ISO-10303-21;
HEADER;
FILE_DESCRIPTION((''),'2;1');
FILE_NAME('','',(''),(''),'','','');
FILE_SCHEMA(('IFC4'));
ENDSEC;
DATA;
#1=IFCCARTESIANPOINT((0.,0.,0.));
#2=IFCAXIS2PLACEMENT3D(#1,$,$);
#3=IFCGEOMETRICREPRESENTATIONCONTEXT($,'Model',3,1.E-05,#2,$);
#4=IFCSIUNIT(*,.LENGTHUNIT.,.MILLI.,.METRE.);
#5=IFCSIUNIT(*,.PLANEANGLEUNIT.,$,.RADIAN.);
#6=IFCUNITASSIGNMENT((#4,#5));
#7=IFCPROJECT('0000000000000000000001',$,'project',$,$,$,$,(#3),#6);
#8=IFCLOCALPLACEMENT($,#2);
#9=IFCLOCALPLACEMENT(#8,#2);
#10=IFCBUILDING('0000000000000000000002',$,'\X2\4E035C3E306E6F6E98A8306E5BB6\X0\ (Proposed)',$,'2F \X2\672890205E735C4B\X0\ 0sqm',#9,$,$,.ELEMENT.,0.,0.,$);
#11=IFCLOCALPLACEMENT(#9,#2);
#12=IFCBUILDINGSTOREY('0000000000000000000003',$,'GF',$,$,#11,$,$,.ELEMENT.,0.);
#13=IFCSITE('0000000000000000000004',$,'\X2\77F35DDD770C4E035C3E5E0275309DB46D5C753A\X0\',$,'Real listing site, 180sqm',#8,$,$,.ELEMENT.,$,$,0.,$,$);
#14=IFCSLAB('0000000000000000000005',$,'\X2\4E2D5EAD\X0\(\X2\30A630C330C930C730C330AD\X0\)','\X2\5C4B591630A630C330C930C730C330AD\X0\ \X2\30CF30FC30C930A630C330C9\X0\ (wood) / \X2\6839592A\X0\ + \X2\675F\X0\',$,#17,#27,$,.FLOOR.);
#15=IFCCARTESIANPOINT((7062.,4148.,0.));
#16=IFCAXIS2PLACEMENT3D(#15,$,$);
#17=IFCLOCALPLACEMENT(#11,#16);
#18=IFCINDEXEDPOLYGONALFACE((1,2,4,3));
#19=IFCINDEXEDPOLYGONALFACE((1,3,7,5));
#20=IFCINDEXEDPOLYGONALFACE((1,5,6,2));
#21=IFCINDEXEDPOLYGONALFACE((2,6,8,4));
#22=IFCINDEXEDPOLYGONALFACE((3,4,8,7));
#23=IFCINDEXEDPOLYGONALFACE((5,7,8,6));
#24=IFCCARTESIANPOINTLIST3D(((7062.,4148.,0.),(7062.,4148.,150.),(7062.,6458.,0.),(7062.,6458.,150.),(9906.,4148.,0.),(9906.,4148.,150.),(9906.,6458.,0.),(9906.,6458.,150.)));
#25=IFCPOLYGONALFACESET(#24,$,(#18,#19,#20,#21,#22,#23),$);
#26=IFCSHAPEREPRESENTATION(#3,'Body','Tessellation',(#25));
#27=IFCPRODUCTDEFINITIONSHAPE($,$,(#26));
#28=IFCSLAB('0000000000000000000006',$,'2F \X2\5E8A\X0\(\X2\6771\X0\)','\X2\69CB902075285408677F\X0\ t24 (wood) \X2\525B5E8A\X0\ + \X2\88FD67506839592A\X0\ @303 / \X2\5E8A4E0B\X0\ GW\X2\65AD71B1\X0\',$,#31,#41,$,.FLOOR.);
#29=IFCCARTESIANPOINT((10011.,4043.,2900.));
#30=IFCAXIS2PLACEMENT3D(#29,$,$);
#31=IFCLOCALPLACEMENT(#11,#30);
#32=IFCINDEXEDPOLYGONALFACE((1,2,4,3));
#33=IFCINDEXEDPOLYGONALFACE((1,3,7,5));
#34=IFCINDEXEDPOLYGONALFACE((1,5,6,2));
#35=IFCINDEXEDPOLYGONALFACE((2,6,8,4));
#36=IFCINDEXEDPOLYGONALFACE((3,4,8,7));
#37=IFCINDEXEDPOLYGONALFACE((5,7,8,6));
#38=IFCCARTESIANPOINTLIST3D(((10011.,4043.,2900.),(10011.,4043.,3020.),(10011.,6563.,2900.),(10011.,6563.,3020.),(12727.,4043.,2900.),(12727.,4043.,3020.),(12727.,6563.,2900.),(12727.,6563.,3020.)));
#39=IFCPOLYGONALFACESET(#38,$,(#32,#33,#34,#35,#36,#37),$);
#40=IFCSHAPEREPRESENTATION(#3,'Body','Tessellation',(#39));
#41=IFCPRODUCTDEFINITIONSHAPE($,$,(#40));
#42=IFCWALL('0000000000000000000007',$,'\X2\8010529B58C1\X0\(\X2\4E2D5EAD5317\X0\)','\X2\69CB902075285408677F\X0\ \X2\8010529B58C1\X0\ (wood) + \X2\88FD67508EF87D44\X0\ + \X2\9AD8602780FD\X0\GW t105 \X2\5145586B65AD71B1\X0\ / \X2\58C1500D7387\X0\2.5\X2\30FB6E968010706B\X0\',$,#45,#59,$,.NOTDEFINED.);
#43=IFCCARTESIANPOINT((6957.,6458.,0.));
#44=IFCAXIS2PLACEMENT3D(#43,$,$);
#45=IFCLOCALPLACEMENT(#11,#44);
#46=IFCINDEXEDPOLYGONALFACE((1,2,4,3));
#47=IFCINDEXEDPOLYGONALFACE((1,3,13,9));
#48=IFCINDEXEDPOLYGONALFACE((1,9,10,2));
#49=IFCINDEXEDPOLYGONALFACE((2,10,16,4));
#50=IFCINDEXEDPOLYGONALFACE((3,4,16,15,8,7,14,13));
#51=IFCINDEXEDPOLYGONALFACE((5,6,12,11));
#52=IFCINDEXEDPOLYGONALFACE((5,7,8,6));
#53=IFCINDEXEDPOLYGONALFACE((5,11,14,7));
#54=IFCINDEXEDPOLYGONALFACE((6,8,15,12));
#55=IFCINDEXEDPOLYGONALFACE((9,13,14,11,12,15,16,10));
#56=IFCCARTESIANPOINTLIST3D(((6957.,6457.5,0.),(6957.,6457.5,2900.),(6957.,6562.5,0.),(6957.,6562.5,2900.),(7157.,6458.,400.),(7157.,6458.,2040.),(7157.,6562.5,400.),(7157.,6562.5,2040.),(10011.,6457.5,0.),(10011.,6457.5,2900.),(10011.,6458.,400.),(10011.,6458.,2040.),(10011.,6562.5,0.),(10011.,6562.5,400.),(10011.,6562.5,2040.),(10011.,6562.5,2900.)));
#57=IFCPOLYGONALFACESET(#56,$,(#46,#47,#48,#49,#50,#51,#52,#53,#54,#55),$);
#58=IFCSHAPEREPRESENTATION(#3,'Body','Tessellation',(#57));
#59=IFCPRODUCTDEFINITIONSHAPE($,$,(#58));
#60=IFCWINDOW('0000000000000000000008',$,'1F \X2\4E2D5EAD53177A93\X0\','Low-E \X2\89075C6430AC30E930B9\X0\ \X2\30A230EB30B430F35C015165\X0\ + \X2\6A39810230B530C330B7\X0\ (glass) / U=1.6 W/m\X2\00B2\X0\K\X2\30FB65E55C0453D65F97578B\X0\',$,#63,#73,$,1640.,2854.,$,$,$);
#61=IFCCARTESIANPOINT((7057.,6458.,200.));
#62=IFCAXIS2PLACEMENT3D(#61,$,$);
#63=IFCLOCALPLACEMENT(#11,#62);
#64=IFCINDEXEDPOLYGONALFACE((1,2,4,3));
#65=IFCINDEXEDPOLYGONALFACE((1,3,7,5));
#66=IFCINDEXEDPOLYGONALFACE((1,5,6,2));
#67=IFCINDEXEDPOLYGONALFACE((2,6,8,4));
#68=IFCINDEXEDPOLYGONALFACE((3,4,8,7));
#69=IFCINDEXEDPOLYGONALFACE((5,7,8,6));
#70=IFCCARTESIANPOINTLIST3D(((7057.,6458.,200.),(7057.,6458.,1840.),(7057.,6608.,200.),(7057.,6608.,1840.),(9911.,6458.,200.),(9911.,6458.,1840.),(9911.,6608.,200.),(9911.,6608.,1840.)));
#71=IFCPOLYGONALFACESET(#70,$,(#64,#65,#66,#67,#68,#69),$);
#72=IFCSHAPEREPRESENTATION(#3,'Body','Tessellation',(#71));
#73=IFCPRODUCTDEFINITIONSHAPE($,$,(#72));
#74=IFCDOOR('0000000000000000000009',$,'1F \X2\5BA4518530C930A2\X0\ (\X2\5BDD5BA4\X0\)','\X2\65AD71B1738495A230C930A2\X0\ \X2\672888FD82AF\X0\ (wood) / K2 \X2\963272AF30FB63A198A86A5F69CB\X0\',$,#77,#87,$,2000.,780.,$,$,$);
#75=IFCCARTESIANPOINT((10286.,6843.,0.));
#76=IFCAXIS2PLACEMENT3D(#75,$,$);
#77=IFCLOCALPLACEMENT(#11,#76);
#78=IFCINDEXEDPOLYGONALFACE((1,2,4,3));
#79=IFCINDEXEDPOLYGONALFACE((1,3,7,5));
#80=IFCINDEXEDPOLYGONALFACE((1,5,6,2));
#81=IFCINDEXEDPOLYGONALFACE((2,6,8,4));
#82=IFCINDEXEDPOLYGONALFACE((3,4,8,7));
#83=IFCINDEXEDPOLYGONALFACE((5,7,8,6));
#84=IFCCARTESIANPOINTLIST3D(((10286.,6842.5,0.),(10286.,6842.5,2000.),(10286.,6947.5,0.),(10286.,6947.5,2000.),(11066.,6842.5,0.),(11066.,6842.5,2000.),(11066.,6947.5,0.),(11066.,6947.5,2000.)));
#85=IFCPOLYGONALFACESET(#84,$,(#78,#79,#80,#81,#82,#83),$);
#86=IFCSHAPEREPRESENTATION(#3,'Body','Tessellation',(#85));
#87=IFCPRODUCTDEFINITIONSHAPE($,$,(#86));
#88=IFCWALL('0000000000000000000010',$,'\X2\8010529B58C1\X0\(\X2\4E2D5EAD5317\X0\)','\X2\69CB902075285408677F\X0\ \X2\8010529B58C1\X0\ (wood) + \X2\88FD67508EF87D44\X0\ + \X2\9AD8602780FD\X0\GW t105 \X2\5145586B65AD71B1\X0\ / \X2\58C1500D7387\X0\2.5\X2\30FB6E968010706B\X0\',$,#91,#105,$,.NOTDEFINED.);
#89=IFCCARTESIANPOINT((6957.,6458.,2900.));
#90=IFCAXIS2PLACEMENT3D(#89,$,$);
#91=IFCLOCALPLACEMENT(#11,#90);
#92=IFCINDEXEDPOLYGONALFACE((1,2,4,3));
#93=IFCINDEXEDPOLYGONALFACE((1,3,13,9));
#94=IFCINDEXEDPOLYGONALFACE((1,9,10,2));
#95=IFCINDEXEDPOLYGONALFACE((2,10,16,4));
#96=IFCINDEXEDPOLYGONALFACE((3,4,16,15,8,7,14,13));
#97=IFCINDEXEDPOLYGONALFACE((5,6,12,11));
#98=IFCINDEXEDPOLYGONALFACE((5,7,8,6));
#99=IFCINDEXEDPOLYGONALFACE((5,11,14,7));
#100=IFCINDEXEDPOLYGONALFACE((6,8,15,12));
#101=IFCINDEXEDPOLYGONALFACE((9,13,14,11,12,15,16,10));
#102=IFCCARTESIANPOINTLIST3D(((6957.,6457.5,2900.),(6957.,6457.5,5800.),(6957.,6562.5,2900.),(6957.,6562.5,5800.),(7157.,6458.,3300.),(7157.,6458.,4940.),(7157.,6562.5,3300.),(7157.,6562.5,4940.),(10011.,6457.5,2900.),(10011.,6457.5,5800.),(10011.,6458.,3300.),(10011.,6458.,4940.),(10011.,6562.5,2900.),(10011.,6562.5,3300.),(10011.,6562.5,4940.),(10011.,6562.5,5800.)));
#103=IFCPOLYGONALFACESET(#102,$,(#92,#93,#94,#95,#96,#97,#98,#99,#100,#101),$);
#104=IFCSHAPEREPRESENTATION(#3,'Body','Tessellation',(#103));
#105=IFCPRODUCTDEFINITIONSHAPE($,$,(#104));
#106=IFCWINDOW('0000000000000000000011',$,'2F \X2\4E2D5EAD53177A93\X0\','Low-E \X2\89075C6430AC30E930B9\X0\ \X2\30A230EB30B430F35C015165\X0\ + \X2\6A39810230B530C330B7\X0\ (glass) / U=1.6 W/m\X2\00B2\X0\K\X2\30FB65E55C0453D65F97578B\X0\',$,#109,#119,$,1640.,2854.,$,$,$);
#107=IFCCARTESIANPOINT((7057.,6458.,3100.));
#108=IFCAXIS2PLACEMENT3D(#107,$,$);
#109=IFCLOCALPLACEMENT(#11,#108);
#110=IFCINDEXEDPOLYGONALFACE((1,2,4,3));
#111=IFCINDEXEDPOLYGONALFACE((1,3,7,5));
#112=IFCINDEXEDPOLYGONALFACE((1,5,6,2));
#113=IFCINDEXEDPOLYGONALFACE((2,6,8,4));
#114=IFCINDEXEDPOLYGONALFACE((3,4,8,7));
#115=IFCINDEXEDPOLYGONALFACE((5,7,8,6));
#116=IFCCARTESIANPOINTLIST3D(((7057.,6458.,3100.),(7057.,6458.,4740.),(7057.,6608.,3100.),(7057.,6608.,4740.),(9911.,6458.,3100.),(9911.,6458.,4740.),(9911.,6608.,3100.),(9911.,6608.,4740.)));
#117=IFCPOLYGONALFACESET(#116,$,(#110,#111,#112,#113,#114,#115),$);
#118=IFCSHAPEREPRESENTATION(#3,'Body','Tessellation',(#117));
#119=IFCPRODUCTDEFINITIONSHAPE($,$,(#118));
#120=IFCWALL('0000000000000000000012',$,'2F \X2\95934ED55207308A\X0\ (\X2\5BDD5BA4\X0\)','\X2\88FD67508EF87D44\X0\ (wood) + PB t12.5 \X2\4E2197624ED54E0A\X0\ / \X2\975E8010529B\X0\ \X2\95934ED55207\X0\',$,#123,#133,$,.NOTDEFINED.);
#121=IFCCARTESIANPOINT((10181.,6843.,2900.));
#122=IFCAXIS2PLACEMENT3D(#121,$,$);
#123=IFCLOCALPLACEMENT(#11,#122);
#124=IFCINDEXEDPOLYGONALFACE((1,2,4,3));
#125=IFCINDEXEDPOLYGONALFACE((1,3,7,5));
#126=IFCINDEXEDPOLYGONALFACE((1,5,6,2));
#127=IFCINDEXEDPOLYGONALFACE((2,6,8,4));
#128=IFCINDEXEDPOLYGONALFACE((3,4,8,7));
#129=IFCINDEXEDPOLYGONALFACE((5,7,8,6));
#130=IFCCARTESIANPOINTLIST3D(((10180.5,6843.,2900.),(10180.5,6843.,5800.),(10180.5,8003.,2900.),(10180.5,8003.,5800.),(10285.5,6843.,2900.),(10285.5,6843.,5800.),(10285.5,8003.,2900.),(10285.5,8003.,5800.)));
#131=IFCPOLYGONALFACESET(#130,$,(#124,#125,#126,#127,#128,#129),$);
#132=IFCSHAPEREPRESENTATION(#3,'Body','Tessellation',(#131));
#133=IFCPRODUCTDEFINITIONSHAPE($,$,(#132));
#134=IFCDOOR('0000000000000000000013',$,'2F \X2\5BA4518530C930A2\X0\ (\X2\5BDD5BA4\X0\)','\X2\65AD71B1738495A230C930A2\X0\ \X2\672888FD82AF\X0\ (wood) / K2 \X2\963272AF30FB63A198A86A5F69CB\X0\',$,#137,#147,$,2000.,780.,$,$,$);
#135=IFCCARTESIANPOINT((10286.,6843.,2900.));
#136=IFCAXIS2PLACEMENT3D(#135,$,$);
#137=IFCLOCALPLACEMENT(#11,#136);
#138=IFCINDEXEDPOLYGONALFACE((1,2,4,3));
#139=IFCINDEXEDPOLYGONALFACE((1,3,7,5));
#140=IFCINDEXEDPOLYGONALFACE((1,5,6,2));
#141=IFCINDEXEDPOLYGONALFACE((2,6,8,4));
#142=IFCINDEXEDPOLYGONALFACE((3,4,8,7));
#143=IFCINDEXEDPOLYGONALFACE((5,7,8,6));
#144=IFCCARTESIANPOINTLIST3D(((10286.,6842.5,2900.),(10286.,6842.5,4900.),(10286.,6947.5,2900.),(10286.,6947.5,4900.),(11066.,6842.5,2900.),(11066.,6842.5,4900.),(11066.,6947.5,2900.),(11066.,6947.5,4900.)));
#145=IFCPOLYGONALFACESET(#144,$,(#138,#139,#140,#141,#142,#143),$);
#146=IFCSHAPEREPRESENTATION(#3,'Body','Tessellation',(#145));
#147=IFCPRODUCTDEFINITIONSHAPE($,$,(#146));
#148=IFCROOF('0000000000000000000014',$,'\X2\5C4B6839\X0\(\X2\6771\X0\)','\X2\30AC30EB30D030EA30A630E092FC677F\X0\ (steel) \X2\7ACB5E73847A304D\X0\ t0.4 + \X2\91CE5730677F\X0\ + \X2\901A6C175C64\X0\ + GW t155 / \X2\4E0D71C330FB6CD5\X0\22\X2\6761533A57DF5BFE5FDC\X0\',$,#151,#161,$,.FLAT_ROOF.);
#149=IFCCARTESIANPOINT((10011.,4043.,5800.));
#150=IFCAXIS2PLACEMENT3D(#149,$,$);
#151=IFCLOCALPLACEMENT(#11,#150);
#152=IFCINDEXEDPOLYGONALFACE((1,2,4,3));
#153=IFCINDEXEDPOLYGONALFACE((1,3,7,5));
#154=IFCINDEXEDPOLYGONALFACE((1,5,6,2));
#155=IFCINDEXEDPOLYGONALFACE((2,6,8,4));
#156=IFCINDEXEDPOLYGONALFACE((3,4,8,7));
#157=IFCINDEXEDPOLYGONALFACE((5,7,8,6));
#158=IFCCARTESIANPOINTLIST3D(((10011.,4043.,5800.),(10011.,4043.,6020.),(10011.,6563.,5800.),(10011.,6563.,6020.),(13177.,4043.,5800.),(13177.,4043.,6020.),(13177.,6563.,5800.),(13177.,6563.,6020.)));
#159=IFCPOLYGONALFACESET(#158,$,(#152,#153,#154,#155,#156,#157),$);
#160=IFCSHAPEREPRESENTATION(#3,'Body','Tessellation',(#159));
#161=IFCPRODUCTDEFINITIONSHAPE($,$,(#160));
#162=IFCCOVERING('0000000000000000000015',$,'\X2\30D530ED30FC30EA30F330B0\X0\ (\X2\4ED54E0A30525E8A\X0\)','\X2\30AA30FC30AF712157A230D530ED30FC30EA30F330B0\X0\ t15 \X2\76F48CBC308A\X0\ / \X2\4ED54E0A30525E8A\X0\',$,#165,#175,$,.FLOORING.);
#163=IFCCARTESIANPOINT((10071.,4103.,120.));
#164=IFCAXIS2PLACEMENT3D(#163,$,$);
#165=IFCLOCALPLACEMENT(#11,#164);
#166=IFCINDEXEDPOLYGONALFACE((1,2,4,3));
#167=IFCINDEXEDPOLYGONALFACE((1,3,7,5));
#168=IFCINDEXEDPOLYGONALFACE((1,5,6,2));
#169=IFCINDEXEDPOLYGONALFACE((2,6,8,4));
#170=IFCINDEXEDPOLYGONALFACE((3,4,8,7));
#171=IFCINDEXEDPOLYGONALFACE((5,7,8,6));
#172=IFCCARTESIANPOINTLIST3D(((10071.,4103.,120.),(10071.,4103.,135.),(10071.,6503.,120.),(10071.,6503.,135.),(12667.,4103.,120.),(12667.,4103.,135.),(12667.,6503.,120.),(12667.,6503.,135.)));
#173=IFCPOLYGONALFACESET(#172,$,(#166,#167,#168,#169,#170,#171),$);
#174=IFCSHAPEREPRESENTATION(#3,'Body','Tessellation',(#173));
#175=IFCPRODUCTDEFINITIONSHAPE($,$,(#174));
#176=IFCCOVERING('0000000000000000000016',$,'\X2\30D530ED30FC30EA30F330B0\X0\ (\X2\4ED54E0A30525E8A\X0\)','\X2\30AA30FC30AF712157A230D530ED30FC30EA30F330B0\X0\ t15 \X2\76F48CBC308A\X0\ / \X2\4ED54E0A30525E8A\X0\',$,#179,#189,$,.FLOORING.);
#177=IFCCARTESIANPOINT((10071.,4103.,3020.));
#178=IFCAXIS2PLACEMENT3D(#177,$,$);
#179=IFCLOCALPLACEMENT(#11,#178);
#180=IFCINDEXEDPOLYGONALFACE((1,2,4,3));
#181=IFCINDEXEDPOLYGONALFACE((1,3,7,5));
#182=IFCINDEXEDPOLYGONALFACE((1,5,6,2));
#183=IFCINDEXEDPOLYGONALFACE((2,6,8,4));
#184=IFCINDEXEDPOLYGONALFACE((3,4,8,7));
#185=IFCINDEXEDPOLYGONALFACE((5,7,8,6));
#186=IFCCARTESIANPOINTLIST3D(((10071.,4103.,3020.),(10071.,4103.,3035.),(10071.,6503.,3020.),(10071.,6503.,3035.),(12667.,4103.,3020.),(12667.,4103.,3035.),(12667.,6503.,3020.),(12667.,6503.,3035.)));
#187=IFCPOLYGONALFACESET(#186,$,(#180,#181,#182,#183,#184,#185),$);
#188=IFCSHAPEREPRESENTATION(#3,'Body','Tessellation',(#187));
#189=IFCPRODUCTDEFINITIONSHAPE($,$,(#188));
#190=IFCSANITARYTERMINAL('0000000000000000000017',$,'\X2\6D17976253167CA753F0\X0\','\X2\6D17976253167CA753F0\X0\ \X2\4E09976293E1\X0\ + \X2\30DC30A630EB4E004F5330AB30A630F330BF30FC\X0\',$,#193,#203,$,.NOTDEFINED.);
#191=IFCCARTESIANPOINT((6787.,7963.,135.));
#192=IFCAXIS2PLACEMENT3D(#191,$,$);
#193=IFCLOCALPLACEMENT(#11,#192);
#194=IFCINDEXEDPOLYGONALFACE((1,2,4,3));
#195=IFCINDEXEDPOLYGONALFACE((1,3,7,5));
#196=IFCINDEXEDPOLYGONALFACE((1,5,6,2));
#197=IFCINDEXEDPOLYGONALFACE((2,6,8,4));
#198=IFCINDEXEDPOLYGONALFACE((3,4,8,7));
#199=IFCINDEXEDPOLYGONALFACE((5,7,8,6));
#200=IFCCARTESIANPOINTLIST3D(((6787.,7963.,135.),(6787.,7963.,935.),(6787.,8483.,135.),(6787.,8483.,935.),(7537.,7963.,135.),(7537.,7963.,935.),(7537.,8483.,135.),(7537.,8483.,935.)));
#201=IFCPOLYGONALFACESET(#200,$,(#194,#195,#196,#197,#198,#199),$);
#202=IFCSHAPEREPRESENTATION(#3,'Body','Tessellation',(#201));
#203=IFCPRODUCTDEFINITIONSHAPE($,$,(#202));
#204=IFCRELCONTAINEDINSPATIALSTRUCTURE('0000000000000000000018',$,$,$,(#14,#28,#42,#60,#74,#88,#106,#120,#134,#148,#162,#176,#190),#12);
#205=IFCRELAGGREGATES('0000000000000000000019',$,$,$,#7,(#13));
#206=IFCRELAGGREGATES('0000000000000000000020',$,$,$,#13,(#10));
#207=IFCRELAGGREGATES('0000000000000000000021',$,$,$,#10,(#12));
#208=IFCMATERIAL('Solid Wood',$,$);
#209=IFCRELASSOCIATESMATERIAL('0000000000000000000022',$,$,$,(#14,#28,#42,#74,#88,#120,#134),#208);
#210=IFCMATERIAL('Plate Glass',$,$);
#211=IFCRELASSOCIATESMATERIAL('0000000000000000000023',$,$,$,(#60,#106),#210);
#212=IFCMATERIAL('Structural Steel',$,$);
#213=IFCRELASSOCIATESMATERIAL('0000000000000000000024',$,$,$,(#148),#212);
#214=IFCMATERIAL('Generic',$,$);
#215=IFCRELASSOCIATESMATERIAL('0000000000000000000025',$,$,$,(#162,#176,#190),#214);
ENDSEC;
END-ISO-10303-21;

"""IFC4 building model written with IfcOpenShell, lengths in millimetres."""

from ifc_helpers import new_model, si_unit, frame, frame_2d, origin, place, context, project, spatial, rectangle, extrude, material, element, fill, save


model = new_model("IFC4")

# Units and contexts
model_context = context("Model", 3, precision=1e-05, world=origin())
ifc_project = project(units=[si_unit("LENGTHUNIT", "METRE", prefix="MILLI"), si_unit("PLANEANGLEUNIT", "RADIAN")], contexts=[model_context])

# Site, building, storey
site_placement = place(None, origin())
site = spatial("IfcSite", under=ifc_project, at=site_placement, Name="石川県七尾市田鶴浜町", ObjectType="Real listing site, 180sqm", CompositionType="ELEMENT", RefElevation=0.0)
building_placement = place(site_placement, origin())
building = spatial("IfcBuilding", under=site, at=building_placement, Name="七尾の潮風の家 (Proposed)", ObjectType="2F 木造平屋 0sqm", CompositionType="ELEMENT", ElevationOfRefHeight=0.0, ElevationOfTerrain=0.0)
storey_placement = place(building_placement, origin())
storey = spatial("IfcBuildingStorey", under=building, at=storey_placement, Name="GF", CompositionType="ELEMENT", Elevation=0.0)

# Slabs
ifc_material_1 = material(Name="Solid Wood")
slab_1_placement = place(storey_placement, frame((7062.0, 4148.0, 0.0)))
element("IfcSlab", 1, at=slab_1_placement, inside=storey, material=ifc_material_1, Name="中庭(ウッドデッキ)", Description="屋外ウッドデッキ ハードウッド (wood) / 根太 + 束", PredefinedType="FLOOR", context=model_context, shape_type="SweptSolid", body=[
    extrude(rectangle(XDim=2844.0, YDim=2310.0, at=frame_2d((1422.0, 1155.0))), frame((7062.0, 4148.0, 0.0)), (0.0, 0.0, 1.0), 150.0),
])
slab_2_placement = place(storey_placement, frame((10011.0, 4043.0, 2900.0)))
element("IfcSlab", 2, at=slab_2_placement, inside=storey, material=ifc_material_1, Name="2F 床(東)", Description="構造用合板 t24 (wood) 剛床 + 製材根太 @303 / 床下 GW断熱", PredefinedType="FLOOR", context=model_context, shape_type="SweptSolid", body=[
    extrude(rectangle(XDim=2716.0, YDim=2520.0, at=frame_2d((1358.0, 1260.0))), frame((10011.0, 4043.0, 2900.0)), (0.0, 0.0, 1.0), 120.0),
])

# Wall, opening, window
wall_1_placement = place(storey_placement, frame((6957.0, 6458.0, 0.0)))
wall_1 = element("IfcWall", 3, at=wall_1_placement, inside=storey, material=ifc_material_1, Name="耐力壁(中庭北)", Description="構造用合板 耐力壁 (wood) + 製材軸組 + 高性能GW t105 充填断熱 / 壁倍率2.5・準耐火", PredefinedType="NOTDEFINED", context=model_context, shape_type="SweptSolid", body=[
    extrude(rectangle(XDim=3054.0, YDim=105.0, at=frame_2d((1527.0, 52.0))), frame((6957.0, 6458.0, 0.0)), (0.0, 0.0, 1.0), 2900.0),
])
opening_1_placement = place(storey_placement, frame((7057.0, 6458.0, 200.0)))
opening_1 = element("IfcOpeningElement", 4, at=opening_1_placement, cuts=wall_1, PredefinedType="NOTDEFINED", context=model_context, shape_type="SweptSolid", body=[
    extrude(rectangle(XDim=2854.0, YDim=150.0, at=frame_2d((1427.0, 75.0))), frame((7057.0, 6458.0, 200.0)), (0.0, 0.0, 1.0), 1640.0),
])
ifc_material_2 = material(Name="Plate Glass")
window_1_placement = place(storey_placement, frame((7057.0, 6458.0, 200.0)))
window_1 = element("IfcWindow", 5, at=window_1_placement, inside=storey, material=ifc_material_2, Name="1F 中庭北窓", Description="Low-E 複層ガラス アルゴン封入 + 樹脂サッシ (glass) / U=1.6 W/m²K・日射取得型", OverallHeight=1640.0, OverallWidth=2854.0, context=model_context, shape_type="SweptSolid", body=[
    extrude(rectangle(XDim=2854.0, YDim=150.0, at=frame_2d((1427.0, 75.0))), frame((7057.0, 6458.0, 200.0)), (0.0, 0.0, 1.0), 1640.0),
])
fill(opening_1, window_1)

# Door
door_1_placement = place(storey_placement, frame((10286.0, 6843.0, 0.0)))
element("IfcDoor", 6, at=door_1_placement, inside=storey, material=ifc_material_1, Name="1F 室内ドア (寝室)", Description="断熱玄関ドア 木製芯 (wood) / K2 防犯・採風機構", OverallHeight=2000.0, OverallWidth=780.0, context=model_context, shape_type="SweptSolid", body=[
    extrude(rectangle(XDim=780.0, YDim=105.0, at=frame_2d((390.0, 52.0))), frame((10286.0, 6843.0, 0.0)), (0.0, 0.0, 1.0), 2000.0),
])

# Wall, opening, window
wall_2_placement = place(storey_placement, frame((6957.0, 6458.0, 2900.0)))
wall_2 = element("IfcWall", 7, at=wall_2_placement, inside=storey, material=ifc_material_1, Name="耐力壁(中庭北)", Description="構造用合板 耐力壁 (wood) + 製材軸組 + 高性能GW t105 充填断熱 / 壁倍率2.5・準耐火", PredefinedType="NOTDEFINED", context=model_context, shape_type="SweptSolid", body=[
    extrude(rectangle(XDim=3054.0, YDim=105.0, at=frame_2d((1527.0, 52.0))), frame((6957.0, 6458.0, 2900.0)), (0.0, 0.0, 1.0), 2900.0),
])
opening_2_placement = place(storey_placement, frame((7057.0, 6458.0, 3100.0)))
opening_2 = element("IfcOpeningElement", 8, at=opening_2_placement, cuts=wall_2, PredefinedType="NOTDEFINED", context=model_context, shape_type="SweptSolid", body=[
    extrude(rectangle(XDim=2854.0, YDim=150.0, at=frame_2d((1427.0, 75.0))), frame((7057.0, 6458.0, 3100.0)), (0.0, 0.0, 1.0), 1640.0),
])
window_2_placement = place(storey_placement, frame((7057.0, 6458.0, 3100.0)))
window_2 = element("IfcWindow", 9, at=window_2_placement, inside=storey, material=ifc_material_2, Name="2F 中庭北窓", Description="Low-E 複層ガラス アルゴン封入 + 樹脂サッシ (glass) / U=1.6 W/m²K・日射取得型", OverallHeight=1640.0, OverallWidth=2854.0, context=model_context, shape_type="SweptSolid", body=[
    extrude(rectangle(XDim=2854.0, YDim=150.0, at=frame_2d((1427.0, 75.0))), frame((7057.0, 6458.0, 3100.0)), (0.0, 0.0, 1.0), 1640.0),
])
fill(opening_2, window_2)

# Wall
wall_3_placement = place(storey_placement, frame((10181.0, 6843.0, 2900.0)))
element("IfcWall", 10, at=wall_3_placement, inside=storey, material=ifc_material_1, Name="2F 間仕切り (寝室)", Description="製材軸組 (wood) + PB t12.5 両面仕上 / 非耐力 間仕切", PredefinedType="NOTDEFINED", context=model_context, shape_type="SweptSolid", body=[
    extrude(rectangle(XDim=105.0, YDim=1160.0, at=frame_2d((52.0, 580.0))), frame((10181.0, 6843.0, 2900.0)), (0.0, 0.0, 1.0), 2900.0),
])

# Door
door_2_placement = place(storey_placement, frame((10286.0, 6843.0, 2900.0)))
element("IfcDoor", 11, at=door_2_placement, inside=storey, material=ifc_material_1, Name="2F 室内ドア (寝室)", Description="断熱玄関ドア 木製芯 (wood) / K2 防犯・採風機構", OverallHeight=2000.0, OverallWidth=780.0, context=model_context, shape_type="SweptSolid", body=[
    extrude(rectangle(XDim=780.0, YDim=105.0, at=frame_2d((390.0, 52.0))), frame((10286.0, 6843.0, 2900.0)), (0.0, 0.0, 1.0), 2000.0),
])

# Roof
ifc_material_3 = material(Name="Structural Steel")
for number, where, name in (
    (12, (10011.0, 4043.0, 5800.0), "屋根(東)"),
):
    element("IfcRoof", number, at=place(storey_placement, frame(where)), inside=storey, material=ifc_material_3, Name=name, Description="ガルバリウム鋼板 (steel) 立平葺き t0.4 + 野地板 + 通気層 + GW t155 / 不燃・法22条区域対応", PredefinedType="FLAT_ROOF", context=model_context, shape_type="SweptSolid", body=[
        extrude(rectangle(XDim=3166.0, YDim=2520.0, at=frame_2d((1583.0, 1260.0))), frame((10011.0, 4043.0, 5800.0)), (0.0, 0.0, 1.0), 220.0),
    ])

# Coverings
ifc_material_4 = material(Name="Generic")
covering_1_placement = place(storey_placement, frame((10071.0, 4103.0, 120.0)))
element("IfcCovering", 13, at=covering_1_placement, inside=storey, material=ifc_material_4, Name="フローリング (仕上げ床)", Description="オーク無垢フローリング t15 直貼り / 仕上げ床", PredefinedType="FLOORING", context=model_context, shape_type="SweptSolid", body=[
    extrude(rectangle(XDim=2596.0, YDim=2400.0, at=frame_2d((1298.0, 1200.0))), frame((10071.0, 4103.0, 120.0)), (0.0, 0.0, 1.0), 15.0),
])
covering_2_placement = place(storey_placement, frame((10071.0, 4103.0, 3020.0)))
element("IfcCovering", 14, at=covering_2_placement, inside=storey, material=ifc_material_4, Name="フローリング (仕上げ床)", Description="オーク無垢フローリング t15 直貼り / 仕上げ床", PredefinedType="FLOORING", context=model_context, shape_type="SweptSolid", body=[
    extrude(rectangle(XDim=2596.0, YDim=2400.0, at=frame_2d((1298.0, 1200.0))), frame((10071.0, 4103.0, 3020.0)), (0.0, 0.0, 1.0), 15.0),
])

# Sanitary terminal
sanitary_terminal_1_placement = place(storey_placement, frame((6787.0, 7963.0, 135.0)))
element("IfcSanitaryTerminal", 15, at=sanitary_terminal_1_placement, inside=storey, material=ifc_material_4, Name="洗面化粧台", Description="洗面化粧台 三面鏡 + ボウル一体カウンター", PredefinedType="NOTDEFINED", context=model_context, shape_type="SweptSolid", body=[
    extrude(rectangle(XDim=750.0, YDim=520.0, at=frame_2d((375.0, 260.0))), frame((6787.0, 7963.0, 135.0)), (0.0, 0.0, 1.0), 800.0),
])

save(model, "model.ifc")
